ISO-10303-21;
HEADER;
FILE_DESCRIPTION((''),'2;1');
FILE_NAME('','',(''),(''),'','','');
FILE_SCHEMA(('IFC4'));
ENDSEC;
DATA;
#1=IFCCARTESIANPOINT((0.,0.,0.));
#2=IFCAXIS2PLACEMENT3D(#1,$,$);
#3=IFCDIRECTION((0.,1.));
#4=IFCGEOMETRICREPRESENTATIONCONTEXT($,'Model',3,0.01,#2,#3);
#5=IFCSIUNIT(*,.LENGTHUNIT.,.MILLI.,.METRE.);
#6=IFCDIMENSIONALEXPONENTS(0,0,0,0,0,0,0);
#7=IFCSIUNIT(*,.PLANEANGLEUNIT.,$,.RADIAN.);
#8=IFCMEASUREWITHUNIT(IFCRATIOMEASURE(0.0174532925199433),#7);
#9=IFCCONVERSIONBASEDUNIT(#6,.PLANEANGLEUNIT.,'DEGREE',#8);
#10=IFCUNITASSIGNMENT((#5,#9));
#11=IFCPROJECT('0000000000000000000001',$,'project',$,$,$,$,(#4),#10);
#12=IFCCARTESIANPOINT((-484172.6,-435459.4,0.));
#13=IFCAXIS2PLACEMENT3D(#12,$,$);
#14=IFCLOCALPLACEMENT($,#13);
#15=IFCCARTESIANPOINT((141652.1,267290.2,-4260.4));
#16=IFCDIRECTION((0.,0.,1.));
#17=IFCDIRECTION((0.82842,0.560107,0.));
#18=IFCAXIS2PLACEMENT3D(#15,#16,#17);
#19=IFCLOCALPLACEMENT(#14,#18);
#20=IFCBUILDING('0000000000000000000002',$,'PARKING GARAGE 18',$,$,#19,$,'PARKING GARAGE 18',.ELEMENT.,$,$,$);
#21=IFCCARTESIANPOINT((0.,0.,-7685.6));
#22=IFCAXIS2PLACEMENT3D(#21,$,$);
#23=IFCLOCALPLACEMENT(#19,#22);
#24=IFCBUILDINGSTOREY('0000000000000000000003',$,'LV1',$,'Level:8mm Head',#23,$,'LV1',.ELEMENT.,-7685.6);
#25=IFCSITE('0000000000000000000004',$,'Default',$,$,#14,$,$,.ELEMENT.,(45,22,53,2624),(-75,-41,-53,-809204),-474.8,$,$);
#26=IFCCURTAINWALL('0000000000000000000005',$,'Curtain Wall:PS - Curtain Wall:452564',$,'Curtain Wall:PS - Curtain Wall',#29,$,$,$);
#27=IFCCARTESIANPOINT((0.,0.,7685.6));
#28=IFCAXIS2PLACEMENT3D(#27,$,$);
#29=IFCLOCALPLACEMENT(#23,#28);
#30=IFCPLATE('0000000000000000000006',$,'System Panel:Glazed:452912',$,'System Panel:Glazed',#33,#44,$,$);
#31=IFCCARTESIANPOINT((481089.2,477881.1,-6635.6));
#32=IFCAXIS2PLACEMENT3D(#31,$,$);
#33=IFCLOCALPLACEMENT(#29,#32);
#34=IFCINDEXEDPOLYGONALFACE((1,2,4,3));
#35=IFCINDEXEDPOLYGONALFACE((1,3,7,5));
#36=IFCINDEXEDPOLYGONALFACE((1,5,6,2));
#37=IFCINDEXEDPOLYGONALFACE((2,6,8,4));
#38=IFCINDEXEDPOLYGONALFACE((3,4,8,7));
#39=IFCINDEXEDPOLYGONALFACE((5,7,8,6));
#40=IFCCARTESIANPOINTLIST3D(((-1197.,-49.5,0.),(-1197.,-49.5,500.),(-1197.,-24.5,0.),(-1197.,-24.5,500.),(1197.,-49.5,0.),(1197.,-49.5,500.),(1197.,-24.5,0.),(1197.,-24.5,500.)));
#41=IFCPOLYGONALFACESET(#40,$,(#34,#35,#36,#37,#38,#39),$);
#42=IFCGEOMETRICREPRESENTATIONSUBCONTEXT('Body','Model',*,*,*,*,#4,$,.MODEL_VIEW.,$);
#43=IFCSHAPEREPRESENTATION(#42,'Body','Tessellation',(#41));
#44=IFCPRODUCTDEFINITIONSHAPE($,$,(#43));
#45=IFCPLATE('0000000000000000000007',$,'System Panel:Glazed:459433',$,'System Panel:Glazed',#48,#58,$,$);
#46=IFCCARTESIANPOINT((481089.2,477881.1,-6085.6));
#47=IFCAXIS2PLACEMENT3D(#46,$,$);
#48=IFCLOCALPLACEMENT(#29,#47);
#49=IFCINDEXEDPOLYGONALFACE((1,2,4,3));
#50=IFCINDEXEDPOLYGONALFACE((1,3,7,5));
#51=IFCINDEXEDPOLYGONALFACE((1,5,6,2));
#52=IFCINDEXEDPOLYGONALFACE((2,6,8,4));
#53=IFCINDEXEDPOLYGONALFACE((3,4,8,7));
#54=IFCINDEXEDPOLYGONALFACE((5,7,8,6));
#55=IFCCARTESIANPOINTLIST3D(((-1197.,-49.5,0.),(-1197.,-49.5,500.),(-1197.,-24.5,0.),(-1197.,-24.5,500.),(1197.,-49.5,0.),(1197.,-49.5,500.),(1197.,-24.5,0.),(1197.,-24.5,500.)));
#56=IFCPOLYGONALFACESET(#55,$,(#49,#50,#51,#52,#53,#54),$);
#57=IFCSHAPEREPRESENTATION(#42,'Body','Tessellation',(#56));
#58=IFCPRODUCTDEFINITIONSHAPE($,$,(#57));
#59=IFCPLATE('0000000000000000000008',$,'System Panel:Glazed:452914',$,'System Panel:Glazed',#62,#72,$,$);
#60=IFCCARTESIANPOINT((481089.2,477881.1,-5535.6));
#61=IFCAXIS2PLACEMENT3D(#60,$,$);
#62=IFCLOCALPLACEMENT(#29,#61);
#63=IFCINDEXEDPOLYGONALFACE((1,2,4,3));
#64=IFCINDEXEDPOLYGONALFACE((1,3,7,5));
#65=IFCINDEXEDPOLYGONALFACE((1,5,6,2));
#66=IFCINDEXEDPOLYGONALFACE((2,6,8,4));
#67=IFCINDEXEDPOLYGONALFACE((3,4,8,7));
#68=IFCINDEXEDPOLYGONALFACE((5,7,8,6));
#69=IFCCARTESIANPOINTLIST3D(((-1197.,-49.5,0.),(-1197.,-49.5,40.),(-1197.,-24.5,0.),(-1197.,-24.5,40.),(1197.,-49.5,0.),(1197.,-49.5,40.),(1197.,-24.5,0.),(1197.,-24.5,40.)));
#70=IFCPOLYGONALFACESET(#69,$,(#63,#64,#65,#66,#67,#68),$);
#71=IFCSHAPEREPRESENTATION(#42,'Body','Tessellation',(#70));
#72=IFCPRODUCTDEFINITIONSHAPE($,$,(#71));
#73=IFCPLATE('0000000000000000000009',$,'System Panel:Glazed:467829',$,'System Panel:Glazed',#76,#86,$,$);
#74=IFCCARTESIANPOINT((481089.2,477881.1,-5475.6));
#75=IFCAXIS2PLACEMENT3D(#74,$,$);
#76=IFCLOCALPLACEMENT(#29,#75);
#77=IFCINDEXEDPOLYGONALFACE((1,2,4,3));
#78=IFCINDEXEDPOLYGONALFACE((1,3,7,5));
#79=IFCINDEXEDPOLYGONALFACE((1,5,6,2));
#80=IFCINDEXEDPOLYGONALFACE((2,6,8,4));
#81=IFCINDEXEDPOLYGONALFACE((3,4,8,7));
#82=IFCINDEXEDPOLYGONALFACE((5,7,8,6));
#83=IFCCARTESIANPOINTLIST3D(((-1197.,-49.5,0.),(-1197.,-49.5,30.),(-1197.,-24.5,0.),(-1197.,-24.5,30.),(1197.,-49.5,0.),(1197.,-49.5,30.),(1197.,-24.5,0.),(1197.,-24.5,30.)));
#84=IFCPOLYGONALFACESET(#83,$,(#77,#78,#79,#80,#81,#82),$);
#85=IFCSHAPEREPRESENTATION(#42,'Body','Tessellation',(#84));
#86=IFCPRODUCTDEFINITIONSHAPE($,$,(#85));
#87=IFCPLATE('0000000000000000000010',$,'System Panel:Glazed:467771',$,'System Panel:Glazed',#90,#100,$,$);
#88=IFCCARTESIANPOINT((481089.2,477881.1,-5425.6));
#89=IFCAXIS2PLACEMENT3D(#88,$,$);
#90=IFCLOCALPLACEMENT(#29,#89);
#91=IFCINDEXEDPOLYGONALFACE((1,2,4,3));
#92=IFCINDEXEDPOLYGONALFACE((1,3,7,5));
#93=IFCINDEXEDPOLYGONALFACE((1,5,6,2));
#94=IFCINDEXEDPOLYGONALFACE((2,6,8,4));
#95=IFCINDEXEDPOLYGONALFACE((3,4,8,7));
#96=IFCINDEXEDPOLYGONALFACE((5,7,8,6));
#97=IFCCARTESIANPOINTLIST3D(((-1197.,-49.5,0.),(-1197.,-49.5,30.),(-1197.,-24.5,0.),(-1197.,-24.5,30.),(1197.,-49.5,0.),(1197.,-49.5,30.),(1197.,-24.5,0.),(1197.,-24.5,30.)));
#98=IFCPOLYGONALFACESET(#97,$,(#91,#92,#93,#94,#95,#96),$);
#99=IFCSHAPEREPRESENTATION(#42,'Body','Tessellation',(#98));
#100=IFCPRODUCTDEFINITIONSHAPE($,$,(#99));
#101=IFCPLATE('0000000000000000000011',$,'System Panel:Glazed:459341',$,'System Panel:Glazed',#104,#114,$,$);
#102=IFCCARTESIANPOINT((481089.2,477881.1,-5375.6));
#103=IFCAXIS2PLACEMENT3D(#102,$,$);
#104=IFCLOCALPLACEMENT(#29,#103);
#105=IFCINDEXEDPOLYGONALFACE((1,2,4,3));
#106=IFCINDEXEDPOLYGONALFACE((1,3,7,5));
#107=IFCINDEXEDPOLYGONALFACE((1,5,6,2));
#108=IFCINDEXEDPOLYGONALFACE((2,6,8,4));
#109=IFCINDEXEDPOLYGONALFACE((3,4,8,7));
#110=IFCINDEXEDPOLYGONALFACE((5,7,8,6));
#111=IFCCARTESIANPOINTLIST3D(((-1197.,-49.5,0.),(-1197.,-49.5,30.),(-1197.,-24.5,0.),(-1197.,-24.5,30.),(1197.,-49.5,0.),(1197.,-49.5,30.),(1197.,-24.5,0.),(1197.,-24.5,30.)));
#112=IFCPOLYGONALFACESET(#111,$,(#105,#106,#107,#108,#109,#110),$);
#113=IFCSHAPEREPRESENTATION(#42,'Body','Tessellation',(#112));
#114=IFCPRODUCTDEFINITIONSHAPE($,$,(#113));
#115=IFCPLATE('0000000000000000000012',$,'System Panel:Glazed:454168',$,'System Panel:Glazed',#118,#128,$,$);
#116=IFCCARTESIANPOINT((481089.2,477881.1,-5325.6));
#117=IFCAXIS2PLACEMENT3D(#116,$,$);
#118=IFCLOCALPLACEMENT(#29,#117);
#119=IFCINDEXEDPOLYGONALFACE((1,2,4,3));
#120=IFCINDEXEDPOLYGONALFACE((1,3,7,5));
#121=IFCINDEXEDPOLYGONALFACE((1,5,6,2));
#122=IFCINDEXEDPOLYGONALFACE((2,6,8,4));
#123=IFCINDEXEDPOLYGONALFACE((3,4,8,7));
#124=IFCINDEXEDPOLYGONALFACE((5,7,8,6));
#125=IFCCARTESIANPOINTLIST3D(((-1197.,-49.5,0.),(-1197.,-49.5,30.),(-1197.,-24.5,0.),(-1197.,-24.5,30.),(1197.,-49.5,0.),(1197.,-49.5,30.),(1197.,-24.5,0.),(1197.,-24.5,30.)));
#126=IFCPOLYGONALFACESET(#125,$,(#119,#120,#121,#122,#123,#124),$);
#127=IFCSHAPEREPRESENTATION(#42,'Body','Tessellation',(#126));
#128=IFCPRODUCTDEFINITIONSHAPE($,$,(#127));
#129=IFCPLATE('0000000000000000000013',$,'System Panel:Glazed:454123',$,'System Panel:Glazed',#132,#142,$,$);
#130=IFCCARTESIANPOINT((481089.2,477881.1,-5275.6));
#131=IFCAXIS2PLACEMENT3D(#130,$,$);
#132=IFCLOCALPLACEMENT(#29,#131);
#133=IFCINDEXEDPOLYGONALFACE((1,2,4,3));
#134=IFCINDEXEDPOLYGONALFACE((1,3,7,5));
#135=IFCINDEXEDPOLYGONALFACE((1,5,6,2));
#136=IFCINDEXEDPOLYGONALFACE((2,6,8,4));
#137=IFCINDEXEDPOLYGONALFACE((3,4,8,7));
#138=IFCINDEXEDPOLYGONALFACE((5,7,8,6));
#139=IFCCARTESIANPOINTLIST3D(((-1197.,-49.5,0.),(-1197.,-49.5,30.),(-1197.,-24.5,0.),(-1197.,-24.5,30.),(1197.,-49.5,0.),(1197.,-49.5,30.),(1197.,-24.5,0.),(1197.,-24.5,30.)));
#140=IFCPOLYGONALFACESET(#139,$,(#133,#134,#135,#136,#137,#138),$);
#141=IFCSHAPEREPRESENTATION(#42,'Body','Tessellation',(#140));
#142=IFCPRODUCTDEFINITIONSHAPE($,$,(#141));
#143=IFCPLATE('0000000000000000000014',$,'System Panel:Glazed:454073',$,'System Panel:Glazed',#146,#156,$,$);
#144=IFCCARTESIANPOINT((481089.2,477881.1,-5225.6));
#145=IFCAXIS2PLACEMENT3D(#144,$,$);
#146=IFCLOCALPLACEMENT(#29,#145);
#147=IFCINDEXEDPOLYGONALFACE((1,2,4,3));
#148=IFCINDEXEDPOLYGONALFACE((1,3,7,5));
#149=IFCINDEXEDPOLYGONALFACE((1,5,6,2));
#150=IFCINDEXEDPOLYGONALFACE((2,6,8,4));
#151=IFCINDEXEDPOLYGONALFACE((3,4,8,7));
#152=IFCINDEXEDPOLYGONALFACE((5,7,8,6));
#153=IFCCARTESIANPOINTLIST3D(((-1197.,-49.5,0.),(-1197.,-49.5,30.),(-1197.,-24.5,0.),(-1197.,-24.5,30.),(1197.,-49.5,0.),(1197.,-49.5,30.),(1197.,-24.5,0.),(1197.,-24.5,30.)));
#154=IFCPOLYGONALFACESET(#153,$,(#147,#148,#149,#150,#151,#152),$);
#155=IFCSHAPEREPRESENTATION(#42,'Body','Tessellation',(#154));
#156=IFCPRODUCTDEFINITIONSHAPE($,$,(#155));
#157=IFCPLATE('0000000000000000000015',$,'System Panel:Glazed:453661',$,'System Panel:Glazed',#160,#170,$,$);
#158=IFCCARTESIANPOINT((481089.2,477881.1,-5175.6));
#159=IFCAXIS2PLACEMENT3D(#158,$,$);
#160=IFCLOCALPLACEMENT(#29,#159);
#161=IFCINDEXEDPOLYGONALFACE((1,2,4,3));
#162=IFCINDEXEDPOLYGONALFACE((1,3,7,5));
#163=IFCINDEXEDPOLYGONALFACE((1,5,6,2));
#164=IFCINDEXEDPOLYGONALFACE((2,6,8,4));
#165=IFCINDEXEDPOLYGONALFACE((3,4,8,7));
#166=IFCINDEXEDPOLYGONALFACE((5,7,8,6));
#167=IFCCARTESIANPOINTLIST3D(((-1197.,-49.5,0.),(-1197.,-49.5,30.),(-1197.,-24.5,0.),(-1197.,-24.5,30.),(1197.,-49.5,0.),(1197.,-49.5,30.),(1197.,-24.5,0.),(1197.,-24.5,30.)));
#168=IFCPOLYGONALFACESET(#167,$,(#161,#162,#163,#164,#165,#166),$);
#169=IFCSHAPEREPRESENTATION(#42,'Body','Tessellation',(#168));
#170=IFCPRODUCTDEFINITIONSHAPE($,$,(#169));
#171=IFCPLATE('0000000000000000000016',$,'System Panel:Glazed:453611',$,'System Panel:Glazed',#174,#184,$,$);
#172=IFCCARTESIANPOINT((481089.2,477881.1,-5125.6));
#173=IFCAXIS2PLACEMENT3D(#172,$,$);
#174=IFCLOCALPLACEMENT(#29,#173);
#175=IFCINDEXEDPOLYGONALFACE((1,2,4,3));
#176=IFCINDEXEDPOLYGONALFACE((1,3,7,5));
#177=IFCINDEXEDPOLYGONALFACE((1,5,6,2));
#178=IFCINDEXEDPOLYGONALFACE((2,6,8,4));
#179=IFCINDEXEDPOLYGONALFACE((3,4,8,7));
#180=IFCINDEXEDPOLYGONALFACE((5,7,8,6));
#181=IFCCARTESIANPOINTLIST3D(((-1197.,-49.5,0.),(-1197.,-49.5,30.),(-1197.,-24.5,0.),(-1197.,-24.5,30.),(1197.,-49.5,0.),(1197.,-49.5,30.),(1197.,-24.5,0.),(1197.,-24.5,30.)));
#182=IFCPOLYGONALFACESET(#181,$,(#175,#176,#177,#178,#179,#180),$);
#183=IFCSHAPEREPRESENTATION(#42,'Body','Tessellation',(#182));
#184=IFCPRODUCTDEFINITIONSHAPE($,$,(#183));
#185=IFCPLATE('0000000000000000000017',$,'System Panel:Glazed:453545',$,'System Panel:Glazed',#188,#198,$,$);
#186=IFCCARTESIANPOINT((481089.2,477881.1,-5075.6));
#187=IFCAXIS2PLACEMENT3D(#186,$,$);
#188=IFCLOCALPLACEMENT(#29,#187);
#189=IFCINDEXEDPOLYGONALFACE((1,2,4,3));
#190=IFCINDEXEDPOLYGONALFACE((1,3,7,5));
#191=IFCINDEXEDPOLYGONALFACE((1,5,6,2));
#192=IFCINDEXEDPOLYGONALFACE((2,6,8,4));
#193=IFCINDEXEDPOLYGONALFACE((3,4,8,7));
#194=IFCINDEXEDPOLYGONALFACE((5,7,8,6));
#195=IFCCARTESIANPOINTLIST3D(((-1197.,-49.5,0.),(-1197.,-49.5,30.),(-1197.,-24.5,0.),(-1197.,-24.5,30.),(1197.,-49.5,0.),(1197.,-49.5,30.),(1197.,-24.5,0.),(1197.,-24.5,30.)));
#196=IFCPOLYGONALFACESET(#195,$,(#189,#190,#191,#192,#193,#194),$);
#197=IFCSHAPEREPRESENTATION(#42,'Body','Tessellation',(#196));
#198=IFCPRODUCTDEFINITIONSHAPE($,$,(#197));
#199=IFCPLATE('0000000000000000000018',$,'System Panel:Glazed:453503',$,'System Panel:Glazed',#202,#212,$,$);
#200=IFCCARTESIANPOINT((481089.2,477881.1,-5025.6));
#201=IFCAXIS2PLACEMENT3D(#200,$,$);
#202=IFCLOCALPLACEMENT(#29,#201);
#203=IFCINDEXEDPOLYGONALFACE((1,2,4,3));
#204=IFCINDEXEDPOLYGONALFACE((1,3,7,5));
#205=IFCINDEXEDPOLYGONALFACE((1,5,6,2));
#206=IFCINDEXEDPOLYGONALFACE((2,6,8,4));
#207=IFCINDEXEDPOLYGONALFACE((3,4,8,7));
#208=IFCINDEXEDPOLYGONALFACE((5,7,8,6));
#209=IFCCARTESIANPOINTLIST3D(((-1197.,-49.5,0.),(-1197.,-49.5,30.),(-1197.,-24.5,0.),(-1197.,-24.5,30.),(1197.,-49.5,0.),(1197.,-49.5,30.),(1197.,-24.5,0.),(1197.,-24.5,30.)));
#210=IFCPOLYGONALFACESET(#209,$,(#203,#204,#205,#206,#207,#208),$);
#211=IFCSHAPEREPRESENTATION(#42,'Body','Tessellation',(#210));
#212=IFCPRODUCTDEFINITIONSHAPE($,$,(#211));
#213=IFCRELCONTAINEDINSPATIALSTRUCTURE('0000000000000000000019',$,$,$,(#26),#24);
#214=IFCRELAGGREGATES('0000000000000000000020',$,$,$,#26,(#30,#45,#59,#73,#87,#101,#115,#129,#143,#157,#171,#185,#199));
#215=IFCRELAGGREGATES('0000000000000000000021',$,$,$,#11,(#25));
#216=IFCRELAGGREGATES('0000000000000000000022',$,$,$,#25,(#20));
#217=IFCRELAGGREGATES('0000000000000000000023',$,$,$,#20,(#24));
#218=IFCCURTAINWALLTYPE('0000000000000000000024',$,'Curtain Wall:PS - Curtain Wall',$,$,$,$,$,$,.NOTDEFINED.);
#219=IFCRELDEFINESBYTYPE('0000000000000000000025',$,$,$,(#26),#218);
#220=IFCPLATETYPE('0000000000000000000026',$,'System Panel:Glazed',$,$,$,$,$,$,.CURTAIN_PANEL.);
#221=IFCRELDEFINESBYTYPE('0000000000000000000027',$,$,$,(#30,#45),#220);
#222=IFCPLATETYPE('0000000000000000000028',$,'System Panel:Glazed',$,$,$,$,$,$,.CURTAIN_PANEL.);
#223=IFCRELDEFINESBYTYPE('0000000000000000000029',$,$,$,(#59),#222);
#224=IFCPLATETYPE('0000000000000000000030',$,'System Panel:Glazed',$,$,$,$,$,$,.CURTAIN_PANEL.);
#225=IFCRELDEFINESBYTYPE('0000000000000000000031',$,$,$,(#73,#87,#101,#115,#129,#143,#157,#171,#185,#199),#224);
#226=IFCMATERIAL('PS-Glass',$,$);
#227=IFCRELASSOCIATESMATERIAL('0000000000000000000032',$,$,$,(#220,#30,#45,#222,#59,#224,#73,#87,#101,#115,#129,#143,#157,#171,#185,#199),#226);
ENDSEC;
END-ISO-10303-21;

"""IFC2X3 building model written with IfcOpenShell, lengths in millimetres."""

from ifc_helpers import new_model, entity, si_unit, converted_unit, direction, frame, frame_2d, origin, place, context, subcontext, project, spatial, rectangle, extrude, source, transform, mapped, material, type_object, type_shapes, element, aggregate, save


model = new_model("IFC2X3")

# Units and contexts
model_context = context("Model", 3, precision=0.01, world=origin(), true_north=direction((0.0, 1.0)))
body_context = subcontext(model_context, "Body", "Model", "MODEL_VIEW")
ifc_project = project(units=[si_unit("LENGTHUNIT", "METRE", prefix="MILLI"), converted_unit("PLANEANGLEUNIT", "DEGREE", entity("IfcRatioMeasure", 0.0174532925199433), si_unit("PLANEANGLEUNIT", "RADIAN"), dimensions=[0, 0, 0, 0, 0, 0, 0])], contexts=[model_context])

# Site, building, storey
site_placement = place(None, frame((-484172.6, -435459.4, 0.0)))
site = spatial("IfcSite", under=ifc_project, at=site_placement, Name="Default", CompositionType="ELEMENT", RefLatitude=(45, 22, 53, 2624), RefLongitude=(-75, -41, -53, -809204), RefElevation=-474.8)
building_placement = place(site_placement, frame((141652.1, 267290.2, -4260.4), z_axis=(0.0, 0.0, 1.0), x_axis=(0.82842, 0.560107, 0.0)))
building = spatial("IfcBuilding", under=site, at=building_placement, Name="PARKING GARAGE 18", LongName="PARKING GARAGE 18", CompositionType="ELEMENT")
storey_placement = place(building_placement, frame((0.0, 0.0, -7685.6)))
storey = spatial("IfcBuildingStorey", under=building, at=storey_placement, Name="LV1", ObjectType="Level:8mm Head", LongName="LV1", CompositionType="ELEMENT", Elevation=-7685.6)

# Curtain wall, plates
curtain_wall_type = type_object("IfcCurtainWallType", Name="Curtain Wall:PS - Curtain Wall", PredefinedType="NOTDEFINED")
curtain_wall_1_placement = place(storey_placement, frame((0.0, 0.0, 7685.6)))
curtain_wall_1 = element("IfcCurtainWall", 1, at=curtain_wall_1_placement, inside=storey, type_object=curtain_wall_type, Name="Curtain Wall:PS - Curtain Wall:452564", ObjectType="Curtain Wall:PS - Curtain Wall")
ifc_material_1 = material(Name="PS-Glass")
plate_type_1 = type_object("IfcPlateType", Name="System Panel:Glazed", PredefinedType="CURTAIN_PANEL", material=ifc_material_1)
shared_shape_1 = source(origin(), body_context, "Body", "SweptSolid", [
    extrude(rectangle(XDim=25.0, YDim=2394.1, at=frame_2d((0.0, 0.0), x_axis=(1.0, 0.0))), frame((0.0, -37.0, 0.0), z_axis=(0.0, 0.0, 1.0), x_axis=(0.0, 1.0, 0.0)), (0.0, 0.0, 1.0), 500.0),
])
type_shapes(plate_type_1, [shared_shape_1])
plate_1_placement = place(curtain_wall_1_placement, frame((481089.2, 477881.1, -6635.6)))
plate_1 = element("IfcPlate", 2, at=plate_1_placement, type_object=plate_type_1, material=ifc_material_1, Name="System Panel:Glazed:452912", ObjectType="System Panel:Glazed", context=body_context, shape_type="MappedRepresentation", body=[
    mapped(shared_shape_1, transform((0.0, 0.0, 0.0), scale=1.0)),
])
plate_2_placement = place(curtain_wall_1_placement, frame((481089.2, 477881.1, -6085.6)))
plate_2 = element("IfcPlate", 3, at=plate_2_placement, type_object=plate_type_1, material=ifc_material_1, Name="System Panel:Glazed:459433", ObjectType="System Panel:Glazed", context=body_context, shape_type="MappedRepresentation", body=[
    mapped(shared_shape_1, transform((0.0, 0.0, 0.0), scale=1.0)),
])
plate_type_2 = type_object("IfcPlateType", Name="System Panel:Glazed", PredefinedType="CURTAIN_PANEL", material=ifc_material_1)
shared_shape_2 = source(origin(), body_context, "Body", "SweptSolid", [
    extrude(rectangle(XDim=25.0, YDim=2394.1, at=frame_2d((0.0, 0.0), x_axis=(1.0, 0.0))), frame((0.0, -37.0, 0.0), z_axis=(0.0, 0.0, 1.0), x_axis=(0.0, 1.0, 0.0)), (0.0, 0.0, 1.0), 40.0),
])
type_shapes(plate_type_2, [shared_shape_2])
plate_3_placement = place(curtain_wall_1_placement, frame((481089.2, 477881.1, -5535.6)))
plate_3 = element("IfcPlate", 4, at=plate_3_placement, type_object=plate_type_2, material=ifc_material_1, Name="System Panel:Glazed:452914", ObjectType="System Panel:Glazed", context=body_context, shape_type="MappedRepresentation", body=[
    mapped(shared_shape_2, transform((0.0, 0.0, 0.0), scale=1.0)),
])
plate_type_3 = type_object("IfcPlateType", Name="System Panel:Glazed", PredefinedType="CURTAIN_PANEL", material=ifc_material_1)
shared_shape_3 = source(origin(), body_context, "Body", "SweptSolid", [
    extrude(rectangle(XDim=25.0, YDim=2394.1, at=frame_2d((0.0, 0.0), x_axis=(1.0, 0.0))), frame((0.0, -37.0, 0.0), z_axis=(0.0, 0.0, 1.0), x_axis=(0.0, 1.0, 0.0)), (0.0, 0.0, 1.0), 30.0),
])
type_shapes(plate_type_3, [shared_shape_3])
plate_4_placement = place(curtain_wall_1_placement, frame((481089.2, 477881.1, -5475.6)))
plate_4 = element("IfcPlate", 5, at=plate_4_placement, type_object=plate_type_3, material=ifc_material_1, Name="System Panel:Glazed:467829", ObjectType="System Panel:Glazed", context=body_context, shape_type="MappedRepresentation", body=[
    mapped(shared_shape_3, transform((0.0, 0.0, 0.0), scale=1.0)),
])
plate_5_placement = place(curtain_wall_1_placement, frame((481089.2, 477881.1, -5425.6)))
plate_5 = element("IfcPlate", 6, at=plate_5_placement, type_object=plate_type_3, material=ifc_material_1, Name="System Panel:Glazed:467771", ObjectType="System Panel:Glazed", context=body_context, shape_type="MappedRepresentation", body=[
    mapped(shared_shape_3, transform((0.0, 0.0, 0.0), scale=1.0)),
])
plate_6_placement = place(curtain_wall_1_placement, frame((481089.2, 477881.1, -5375.6)))
plate_6 = element("IfcPlate", 7, at=plate_6_placement, type_object=plate_type_3, material=ifc_material_1, Name="System Panel:Glazed:459341", ObjectType="System Panel:Glazed", context=body_context, shape_type="MappedRepresentation", body=[
    mapped(shared_shape_3, transform((0.0, 0.0, 0.0), scale=1.0)),
])
plate_7_placement = place(curtain_wall_1_placement, frame((481089.2, 477881.1, -5325.6)))
plate_7 = element("IfcPlate", 8, at=plate_7_placement, type_object=plate_type_3, material=ifc_material_1, Name="System Panel:Glazed:454168", ObjectType="System Panel:Glazed", context=body_context, shape_type="MappedRepresentation", body=[
    mapped(shared_shape_3, transform((0.0, 0.0, 0.0), scale=1.0)),
])
plate_8_placement = place(curtain_wall_1_placement, frame((481089.2, 477881.1, -5275.6)))
plate_8 = element("IfcPlate", 9, at=plate_8_placement, type_object=plate_type_3, material=ifc_material_1, Name="System Panel:Glazed:454123", ObjectType="System Panel:Glazed", context=body_context, shape_type="MappedRepresentation", body=[
    mapped(shared_shape_3, transform((0.0, 0.0, 0.0), scale=1.0)),
])
plate_9_placement = place(curtain_wall_1_placement, frame((481089.2, 477881.1, -5225.6)))
plate_9 = element("IfcPlate", 10, at=plate_9_placement, type_object=plate_type_3, material=ifc_material_1, Name="System Panel:Glazed:454073", ObjectType="System Panel:Glazed", context=body_context, shape_type="MappedRepresentation", body=[
    mapped(shared_shape_3, transform((0.0, 0.0, 0.0), scale=1.0)),
])
plate_10_placement = place(curtain_wall_1_placement, frame((481089.2, 477881.1, -5175.6)))
plate_10 = element("IfcPlate", 11, at=plate_10_placement, type_object=plate_type_3, material=ifc_material_1, Name="System Panel:Glazed:453661", ObjectType="System Panel:Glazed", context=body_context, shape_type="MappedRepresentation", body=[
    mapped(shared_shape_3, transform((0.0, 0.0, 0.0), scale=1.0)),
])
plate_11_placement = place(curtain_wall_1_placement, frame((481089.2, 477881.1, -5125.6)))
plate_11 = element("IfcPlate", 12, at=plate_11_placement, type_object=plate_type_3, material=ifc_material_1, Name="System Panel:Glazed:453611", ObjectType="System Panel:Glazed", context=body_context, shape_type="MappedRepresentation", body=[
    mapped(shared_shape_3, transform((0.0, 0.0, 0.0), scale=1.0)),
])
plate_12_placement = place(curtain_wall_1_placement, frame((481089.2, 477881.1, -5075.6)))
plate_12 = element("IfcPlate", 13, at=plate_12_placement, type_object=plate_type_3, material=ifc_material_1, Name="System Panel:Glazed:453545", ObjectType="System Panel:Glazed", context=body_context, shape_type="MappedRepresentation", body=[
    mapped(shared_shape_3, transform((0.0, 0.0, 0.0), scale=1.0)),
])
plate_13_placement = place(curtain_wall_1_placement, frame((481089.2, 477881.1, -5025.6)))
plate_13 = element("IfcPlate", 14, at=plate_13_placement, type_object=plate_type_3, material=ifc_material_1, Name="System Panel:Glazed:453503", ObjectType="System Panel:Glazed", context=body_context, shape_type="MappedRepresentation", body=[
    mapped(shared_shape_3, transform((0.0, 0.0, 0.0), scale=1.0)),
])
aggregate(curtain_wall_1, [plate_1, plate_2, plate_3, plate_4, plate_5, plate_6, plate_7, plate_8, plate_9, plate_10, plate_11, plate_12, plate_13])

save(model, "model.ifc")
